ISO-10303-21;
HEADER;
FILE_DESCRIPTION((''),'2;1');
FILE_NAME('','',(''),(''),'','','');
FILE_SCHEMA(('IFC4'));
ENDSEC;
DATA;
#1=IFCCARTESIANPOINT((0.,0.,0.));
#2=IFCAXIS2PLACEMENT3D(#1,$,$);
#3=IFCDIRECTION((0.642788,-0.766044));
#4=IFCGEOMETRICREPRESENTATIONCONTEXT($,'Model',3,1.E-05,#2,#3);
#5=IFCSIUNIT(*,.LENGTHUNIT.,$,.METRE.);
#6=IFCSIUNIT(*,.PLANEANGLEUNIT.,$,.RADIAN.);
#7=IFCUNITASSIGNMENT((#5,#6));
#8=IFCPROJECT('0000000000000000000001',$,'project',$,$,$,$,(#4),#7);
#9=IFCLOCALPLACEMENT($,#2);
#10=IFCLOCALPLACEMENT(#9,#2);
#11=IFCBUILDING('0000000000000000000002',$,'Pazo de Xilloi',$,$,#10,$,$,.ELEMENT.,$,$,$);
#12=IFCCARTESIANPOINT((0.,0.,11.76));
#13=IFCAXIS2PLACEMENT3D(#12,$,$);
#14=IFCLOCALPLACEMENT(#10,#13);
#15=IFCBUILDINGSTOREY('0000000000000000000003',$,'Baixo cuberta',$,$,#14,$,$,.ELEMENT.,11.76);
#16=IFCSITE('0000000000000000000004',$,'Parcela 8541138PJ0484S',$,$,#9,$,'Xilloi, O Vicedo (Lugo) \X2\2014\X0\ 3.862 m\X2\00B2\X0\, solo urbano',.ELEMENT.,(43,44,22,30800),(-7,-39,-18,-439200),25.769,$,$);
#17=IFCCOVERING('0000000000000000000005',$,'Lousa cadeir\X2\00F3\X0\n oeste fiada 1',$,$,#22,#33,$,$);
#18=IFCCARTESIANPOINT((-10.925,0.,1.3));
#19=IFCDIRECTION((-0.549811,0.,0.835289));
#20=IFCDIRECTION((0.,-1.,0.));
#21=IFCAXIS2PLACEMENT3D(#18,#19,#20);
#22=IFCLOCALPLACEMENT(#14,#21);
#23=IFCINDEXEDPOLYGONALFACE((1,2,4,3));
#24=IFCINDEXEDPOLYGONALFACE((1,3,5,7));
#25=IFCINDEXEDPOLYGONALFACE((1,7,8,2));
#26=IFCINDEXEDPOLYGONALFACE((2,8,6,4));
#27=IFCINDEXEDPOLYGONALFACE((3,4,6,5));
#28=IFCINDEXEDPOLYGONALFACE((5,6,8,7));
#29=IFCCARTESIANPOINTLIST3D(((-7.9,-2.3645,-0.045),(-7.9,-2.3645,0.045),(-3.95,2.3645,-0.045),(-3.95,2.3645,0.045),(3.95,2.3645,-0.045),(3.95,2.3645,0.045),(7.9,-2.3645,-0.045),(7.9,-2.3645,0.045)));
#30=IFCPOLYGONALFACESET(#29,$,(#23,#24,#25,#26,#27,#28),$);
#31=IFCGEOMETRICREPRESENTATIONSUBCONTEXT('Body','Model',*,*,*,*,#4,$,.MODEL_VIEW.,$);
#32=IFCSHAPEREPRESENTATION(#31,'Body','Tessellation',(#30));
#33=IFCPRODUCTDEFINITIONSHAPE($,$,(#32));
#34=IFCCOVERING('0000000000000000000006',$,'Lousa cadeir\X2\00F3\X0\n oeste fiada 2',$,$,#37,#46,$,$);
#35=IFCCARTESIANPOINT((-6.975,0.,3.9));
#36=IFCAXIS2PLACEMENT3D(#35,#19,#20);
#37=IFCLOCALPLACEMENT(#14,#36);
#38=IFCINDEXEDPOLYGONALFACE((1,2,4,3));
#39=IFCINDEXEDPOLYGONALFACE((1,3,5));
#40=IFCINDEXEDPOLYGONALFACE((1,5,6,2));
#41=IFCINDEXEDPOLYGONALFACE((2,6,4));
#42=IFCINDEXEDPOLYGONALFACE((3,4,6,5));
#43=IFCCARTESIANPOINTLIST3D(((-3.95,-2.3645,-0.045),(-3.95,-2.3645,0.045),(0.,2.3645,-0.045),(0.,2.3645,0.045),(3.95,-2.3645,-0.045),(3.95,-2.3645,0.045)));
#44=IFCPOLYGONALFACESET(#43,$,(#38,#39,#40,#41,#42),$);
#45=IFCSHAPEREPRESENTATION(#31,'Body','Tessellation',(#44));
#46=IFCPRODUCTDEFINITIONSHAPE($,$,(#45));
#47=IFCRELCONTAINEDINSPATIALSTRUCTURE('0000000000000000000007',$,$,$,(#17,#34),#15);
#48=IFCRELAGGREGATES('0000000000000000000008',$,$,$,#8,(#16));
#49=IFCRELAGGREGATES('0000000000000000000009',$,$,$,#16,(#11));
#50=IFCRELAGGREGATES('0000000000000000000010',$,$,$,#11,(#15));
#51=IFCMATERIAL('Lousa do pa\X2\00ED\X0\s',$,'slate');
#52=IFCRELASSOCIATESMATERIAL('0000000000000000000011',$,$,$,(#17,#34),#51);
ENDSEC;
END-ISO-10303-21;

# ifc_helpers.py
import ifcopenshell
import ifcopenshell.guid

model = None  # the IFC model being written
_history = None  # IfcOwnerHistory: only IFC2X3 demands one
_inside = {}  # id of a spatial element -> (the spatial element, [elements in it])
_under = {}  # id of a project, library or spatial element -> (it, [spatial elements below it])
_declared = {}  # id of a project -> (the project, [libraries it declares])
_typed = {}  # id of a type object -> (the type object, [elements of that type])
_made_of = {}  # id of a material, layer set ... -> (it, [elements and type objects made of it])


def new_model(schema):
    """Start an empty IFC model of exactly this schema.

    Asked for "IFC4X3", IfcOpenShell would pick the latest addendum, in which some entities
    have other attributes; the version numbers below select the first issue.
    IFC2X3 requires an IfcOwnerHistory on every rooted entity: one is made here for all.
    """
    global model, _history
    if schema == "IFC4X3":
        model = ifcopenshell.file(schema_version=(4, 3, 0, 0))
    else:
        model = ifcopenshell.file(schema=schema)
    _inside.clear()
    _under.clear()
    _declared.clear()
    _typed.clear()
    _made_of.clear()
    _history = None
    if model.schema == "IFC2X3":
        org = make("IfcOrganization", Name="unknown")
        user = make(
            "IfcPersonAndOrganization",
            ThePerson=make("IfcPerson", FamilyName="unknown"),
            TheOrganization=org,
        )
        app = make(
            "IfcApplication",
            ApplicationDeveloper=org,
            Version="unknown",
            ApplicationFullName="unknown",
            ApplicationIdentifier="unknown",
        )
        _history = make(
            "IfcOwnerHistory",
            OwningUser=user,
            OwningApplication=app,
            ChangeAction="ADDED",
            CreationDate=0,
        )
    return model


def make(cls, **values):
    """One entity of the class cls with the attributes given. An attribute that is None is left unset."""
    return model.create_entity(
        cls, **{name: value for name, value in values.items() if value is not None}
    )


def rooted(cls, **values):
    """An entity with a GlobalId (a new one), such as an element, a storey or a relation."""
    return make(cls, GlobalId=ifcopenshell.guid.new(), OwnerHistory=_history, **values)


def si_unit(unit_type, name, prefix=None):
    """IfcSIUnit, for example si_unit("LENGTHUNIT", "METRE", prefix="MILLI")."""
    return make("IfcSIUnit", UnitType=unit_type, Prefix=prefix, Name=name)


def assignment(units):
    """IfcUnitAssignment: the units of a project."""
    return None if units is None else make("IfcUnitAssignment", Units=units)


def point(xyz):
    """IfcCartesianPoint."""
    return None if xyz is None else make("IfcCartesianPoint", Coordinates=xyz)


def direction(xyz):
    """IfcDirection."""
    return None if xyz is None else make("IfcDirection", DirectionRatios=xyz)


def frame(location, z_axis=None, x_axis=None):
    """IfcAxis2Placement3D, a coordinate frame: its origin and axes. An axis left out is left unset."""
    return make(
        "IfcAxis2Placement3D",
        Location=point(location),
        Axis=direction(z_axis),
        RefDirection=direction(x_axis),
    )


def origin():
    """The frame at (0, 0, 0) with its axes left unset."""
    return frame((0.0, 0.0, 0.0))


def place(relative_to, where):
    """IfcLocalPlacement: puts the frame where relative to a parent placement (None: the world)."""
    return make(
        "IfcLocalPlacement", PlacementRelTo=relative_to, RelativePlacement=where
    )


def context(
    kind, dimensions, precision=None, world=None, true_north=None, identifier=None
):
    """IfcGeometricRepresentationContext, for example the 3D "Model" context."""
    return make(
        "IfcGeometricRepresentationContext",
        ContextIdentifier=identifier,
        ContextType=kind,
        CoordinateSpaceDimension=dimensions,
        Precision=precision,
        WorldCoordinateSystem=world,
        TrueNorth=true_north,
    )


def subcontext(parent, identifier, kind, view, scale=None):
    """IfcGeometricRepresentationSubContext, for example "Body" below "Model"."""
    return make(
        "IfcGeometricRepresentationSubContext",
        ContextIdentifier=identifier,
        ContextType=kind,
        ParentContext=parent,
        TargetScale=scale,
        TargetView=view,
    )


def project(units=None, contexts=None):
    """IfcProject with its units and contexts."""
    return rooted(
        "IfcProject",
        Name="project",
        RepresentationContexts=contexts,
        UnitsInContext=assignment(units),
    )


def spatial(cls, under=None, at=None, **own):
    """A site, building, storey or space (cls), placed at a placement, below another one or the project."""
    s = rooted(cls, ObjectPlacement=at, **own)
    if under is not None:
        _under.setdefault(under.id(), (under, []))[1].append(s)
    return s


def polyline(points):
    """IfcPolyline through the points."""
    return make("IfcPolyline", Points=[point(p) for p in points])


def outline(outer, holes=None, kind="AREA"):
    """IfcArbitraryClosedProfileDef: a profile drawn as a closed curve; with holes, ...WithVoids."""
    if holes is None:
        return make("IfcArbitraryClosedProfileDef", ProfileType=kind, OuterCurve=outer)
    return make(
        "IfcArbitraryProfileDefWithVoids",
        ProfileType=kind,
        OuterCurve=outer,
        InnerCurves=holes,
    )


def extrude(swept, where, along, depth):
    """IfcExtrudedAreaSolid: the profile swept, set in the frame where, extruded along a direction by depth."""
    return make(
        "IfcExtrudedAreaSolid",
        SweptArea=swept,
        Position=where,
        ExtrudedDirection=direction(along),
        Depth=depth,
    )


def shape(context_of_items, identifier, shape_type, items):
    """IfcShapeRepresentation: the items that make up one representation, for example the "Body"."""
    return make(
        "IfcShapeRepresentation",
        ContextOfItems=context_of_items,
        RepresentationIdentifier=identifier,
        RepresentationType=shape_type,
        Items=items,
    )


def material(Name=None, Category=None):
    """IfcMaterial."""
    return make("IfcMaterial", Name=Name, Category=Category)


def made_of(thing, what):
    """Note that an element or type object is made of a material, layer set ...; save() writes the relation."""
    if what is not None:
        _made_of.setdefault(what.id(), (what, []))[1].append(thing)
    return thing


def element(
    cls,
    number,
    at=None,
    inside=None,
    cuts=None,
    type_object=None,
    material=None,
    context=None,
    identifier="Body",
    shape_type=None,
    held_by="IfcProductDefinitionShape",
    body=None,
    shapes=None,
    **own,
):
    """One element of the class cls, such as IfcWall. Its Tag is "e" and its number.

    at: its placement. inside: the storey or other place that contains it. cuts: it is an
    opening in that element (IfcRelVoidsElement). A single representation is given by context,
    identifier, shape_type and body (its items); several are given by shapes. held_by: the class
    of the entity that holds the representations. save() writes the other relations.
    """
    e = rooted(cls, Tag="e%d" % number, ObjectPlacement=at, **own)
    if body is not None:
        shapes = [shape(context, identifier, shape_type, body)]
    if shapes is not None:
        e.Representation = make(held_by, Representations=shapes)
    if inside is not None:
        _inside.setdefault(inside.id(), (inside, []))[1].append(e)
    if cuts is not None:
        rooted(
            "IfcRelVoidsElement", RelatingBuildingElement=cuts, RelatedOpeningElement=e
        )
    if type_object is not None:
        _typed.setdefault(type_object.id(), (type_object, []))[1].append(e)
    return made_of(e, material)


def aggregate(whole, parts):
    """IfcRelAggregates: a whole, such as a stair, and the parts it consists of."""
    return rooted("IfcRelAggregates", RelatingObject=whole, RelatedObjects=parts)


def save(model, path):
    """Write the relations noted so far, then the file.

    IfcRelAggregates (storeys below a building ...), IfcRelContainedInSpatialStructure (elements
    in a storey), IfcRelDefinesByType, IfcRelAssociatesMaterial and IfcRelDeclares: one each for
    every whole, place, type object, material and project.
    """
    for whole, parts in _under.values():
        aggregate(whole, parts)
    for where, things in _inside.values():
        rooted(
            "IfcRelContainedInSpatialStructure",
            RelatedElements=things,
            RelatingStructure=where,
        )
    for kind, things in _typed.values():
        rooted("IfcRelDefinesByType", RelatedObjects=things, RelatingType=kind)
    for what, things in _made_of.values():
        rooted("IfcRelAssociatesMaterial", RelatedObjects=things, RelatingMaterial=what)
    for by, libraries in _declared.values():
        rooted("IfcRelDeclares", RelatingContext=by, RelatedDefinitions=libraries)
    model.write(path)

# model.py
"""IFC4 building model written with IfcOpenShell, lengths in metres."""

from ifc_helpers import new_model, si_unit, direction, frame, origin, place, context, subcontext, project, spatial, polyline, outline, extrude, material, element, save


model = new_model("IFC4")

# Units and contexts
model_context = context("Model", 3, precision=1e-05, world=origin(), true_north=direction((0.642788, -0.766044)))
body_context = subcontext(model_context, "Body", "Model", "MODEL_VIEW")
ifc_project = project(units=[si_unit("LENGTHUNIT", "METRE"), si_unit("PLANEANGLEUNIT", "RADIAN")], contexts=[model_context])

# Site, building, storey
site_placement = place(None, origin())
site = spatial("IfcSite", under=ifc_project, at=site_placement, Name="Parcela 8541138PJ0484S", LongName="Xilloi, O Vicedo (Lugo) — 3.862 m², solo urbano", CompositionType="ELEMENT", RefLatitude=(43, 44, 22, 30800), RefLongitude=(-7, -39, -18, -439200), RefElevation=25.769)
building_placement = place(site_placement, origin())
building = spatial("IfcBuilding", under=site, at=building_placement, Name="Pazo de Xilloi", CompositionType="ELEMENT")
storey_placement = place(building_placement, frame((0.0, 0.0, 11.76)))
storey = spatial("IfcBuildingStorey", under=building, at=storey_placement, Name="Baixo cuberta", CompositionType="ELEMENT", Elevation=11.76)

# Shared definitions
ifc_material_1 = material(Name="Lousa do país", Category="slate")

# Coverings
covering_1_placement = place(storey_placement, frame((-10.925, 0.0, 1.3), z_axis=(-0.549811, 0.0, 0.835289), x_axis=(0.0, -1.0, 0.0)))
element("IfcCovering", 1, at=covering_1_placement, inside=storey, material=ifc_material_1, Name="Lousa cadeirón oeste fiada 1", context=body_context, shape_type="SweptSolid", body=[
    extrude(outline(polyline([(-7.9, -2.3645), (7.9, -2.3645), (3.95, 2.3645), (-3.95, 2.3645), (-7.9, -2.3645)])), frame((0.0, 0.0, -0.045)), (0.0, 0.0, 1.0), 0.09),
])
covering_2_placement = place(storey_placement, frame((-6.975, 0.0, 3.9), z_axis=(-0.549811, 0.0, 0.835289), x_axis=(0.0, -1.0, 0.0)))
element("IfcCovering", 2, at=covering_2_placement, inside=storey, material=ifc_material_1, Name="Lousa cadeirón oeste fiada 2", context=body_context, shape_type="SweptSolid", body=[
    extrude(outline(polyline([(-3.95, -2.3645), (3.95, -2.3645), (0.0, 2.3645), (0.0, 2.3645), (-3.95, -2.3645)])), frame((0.0, 0.0, -0.045)), (0.0, 0.0, 1.0), 0.09),
])

save(model, "model.ifc")
